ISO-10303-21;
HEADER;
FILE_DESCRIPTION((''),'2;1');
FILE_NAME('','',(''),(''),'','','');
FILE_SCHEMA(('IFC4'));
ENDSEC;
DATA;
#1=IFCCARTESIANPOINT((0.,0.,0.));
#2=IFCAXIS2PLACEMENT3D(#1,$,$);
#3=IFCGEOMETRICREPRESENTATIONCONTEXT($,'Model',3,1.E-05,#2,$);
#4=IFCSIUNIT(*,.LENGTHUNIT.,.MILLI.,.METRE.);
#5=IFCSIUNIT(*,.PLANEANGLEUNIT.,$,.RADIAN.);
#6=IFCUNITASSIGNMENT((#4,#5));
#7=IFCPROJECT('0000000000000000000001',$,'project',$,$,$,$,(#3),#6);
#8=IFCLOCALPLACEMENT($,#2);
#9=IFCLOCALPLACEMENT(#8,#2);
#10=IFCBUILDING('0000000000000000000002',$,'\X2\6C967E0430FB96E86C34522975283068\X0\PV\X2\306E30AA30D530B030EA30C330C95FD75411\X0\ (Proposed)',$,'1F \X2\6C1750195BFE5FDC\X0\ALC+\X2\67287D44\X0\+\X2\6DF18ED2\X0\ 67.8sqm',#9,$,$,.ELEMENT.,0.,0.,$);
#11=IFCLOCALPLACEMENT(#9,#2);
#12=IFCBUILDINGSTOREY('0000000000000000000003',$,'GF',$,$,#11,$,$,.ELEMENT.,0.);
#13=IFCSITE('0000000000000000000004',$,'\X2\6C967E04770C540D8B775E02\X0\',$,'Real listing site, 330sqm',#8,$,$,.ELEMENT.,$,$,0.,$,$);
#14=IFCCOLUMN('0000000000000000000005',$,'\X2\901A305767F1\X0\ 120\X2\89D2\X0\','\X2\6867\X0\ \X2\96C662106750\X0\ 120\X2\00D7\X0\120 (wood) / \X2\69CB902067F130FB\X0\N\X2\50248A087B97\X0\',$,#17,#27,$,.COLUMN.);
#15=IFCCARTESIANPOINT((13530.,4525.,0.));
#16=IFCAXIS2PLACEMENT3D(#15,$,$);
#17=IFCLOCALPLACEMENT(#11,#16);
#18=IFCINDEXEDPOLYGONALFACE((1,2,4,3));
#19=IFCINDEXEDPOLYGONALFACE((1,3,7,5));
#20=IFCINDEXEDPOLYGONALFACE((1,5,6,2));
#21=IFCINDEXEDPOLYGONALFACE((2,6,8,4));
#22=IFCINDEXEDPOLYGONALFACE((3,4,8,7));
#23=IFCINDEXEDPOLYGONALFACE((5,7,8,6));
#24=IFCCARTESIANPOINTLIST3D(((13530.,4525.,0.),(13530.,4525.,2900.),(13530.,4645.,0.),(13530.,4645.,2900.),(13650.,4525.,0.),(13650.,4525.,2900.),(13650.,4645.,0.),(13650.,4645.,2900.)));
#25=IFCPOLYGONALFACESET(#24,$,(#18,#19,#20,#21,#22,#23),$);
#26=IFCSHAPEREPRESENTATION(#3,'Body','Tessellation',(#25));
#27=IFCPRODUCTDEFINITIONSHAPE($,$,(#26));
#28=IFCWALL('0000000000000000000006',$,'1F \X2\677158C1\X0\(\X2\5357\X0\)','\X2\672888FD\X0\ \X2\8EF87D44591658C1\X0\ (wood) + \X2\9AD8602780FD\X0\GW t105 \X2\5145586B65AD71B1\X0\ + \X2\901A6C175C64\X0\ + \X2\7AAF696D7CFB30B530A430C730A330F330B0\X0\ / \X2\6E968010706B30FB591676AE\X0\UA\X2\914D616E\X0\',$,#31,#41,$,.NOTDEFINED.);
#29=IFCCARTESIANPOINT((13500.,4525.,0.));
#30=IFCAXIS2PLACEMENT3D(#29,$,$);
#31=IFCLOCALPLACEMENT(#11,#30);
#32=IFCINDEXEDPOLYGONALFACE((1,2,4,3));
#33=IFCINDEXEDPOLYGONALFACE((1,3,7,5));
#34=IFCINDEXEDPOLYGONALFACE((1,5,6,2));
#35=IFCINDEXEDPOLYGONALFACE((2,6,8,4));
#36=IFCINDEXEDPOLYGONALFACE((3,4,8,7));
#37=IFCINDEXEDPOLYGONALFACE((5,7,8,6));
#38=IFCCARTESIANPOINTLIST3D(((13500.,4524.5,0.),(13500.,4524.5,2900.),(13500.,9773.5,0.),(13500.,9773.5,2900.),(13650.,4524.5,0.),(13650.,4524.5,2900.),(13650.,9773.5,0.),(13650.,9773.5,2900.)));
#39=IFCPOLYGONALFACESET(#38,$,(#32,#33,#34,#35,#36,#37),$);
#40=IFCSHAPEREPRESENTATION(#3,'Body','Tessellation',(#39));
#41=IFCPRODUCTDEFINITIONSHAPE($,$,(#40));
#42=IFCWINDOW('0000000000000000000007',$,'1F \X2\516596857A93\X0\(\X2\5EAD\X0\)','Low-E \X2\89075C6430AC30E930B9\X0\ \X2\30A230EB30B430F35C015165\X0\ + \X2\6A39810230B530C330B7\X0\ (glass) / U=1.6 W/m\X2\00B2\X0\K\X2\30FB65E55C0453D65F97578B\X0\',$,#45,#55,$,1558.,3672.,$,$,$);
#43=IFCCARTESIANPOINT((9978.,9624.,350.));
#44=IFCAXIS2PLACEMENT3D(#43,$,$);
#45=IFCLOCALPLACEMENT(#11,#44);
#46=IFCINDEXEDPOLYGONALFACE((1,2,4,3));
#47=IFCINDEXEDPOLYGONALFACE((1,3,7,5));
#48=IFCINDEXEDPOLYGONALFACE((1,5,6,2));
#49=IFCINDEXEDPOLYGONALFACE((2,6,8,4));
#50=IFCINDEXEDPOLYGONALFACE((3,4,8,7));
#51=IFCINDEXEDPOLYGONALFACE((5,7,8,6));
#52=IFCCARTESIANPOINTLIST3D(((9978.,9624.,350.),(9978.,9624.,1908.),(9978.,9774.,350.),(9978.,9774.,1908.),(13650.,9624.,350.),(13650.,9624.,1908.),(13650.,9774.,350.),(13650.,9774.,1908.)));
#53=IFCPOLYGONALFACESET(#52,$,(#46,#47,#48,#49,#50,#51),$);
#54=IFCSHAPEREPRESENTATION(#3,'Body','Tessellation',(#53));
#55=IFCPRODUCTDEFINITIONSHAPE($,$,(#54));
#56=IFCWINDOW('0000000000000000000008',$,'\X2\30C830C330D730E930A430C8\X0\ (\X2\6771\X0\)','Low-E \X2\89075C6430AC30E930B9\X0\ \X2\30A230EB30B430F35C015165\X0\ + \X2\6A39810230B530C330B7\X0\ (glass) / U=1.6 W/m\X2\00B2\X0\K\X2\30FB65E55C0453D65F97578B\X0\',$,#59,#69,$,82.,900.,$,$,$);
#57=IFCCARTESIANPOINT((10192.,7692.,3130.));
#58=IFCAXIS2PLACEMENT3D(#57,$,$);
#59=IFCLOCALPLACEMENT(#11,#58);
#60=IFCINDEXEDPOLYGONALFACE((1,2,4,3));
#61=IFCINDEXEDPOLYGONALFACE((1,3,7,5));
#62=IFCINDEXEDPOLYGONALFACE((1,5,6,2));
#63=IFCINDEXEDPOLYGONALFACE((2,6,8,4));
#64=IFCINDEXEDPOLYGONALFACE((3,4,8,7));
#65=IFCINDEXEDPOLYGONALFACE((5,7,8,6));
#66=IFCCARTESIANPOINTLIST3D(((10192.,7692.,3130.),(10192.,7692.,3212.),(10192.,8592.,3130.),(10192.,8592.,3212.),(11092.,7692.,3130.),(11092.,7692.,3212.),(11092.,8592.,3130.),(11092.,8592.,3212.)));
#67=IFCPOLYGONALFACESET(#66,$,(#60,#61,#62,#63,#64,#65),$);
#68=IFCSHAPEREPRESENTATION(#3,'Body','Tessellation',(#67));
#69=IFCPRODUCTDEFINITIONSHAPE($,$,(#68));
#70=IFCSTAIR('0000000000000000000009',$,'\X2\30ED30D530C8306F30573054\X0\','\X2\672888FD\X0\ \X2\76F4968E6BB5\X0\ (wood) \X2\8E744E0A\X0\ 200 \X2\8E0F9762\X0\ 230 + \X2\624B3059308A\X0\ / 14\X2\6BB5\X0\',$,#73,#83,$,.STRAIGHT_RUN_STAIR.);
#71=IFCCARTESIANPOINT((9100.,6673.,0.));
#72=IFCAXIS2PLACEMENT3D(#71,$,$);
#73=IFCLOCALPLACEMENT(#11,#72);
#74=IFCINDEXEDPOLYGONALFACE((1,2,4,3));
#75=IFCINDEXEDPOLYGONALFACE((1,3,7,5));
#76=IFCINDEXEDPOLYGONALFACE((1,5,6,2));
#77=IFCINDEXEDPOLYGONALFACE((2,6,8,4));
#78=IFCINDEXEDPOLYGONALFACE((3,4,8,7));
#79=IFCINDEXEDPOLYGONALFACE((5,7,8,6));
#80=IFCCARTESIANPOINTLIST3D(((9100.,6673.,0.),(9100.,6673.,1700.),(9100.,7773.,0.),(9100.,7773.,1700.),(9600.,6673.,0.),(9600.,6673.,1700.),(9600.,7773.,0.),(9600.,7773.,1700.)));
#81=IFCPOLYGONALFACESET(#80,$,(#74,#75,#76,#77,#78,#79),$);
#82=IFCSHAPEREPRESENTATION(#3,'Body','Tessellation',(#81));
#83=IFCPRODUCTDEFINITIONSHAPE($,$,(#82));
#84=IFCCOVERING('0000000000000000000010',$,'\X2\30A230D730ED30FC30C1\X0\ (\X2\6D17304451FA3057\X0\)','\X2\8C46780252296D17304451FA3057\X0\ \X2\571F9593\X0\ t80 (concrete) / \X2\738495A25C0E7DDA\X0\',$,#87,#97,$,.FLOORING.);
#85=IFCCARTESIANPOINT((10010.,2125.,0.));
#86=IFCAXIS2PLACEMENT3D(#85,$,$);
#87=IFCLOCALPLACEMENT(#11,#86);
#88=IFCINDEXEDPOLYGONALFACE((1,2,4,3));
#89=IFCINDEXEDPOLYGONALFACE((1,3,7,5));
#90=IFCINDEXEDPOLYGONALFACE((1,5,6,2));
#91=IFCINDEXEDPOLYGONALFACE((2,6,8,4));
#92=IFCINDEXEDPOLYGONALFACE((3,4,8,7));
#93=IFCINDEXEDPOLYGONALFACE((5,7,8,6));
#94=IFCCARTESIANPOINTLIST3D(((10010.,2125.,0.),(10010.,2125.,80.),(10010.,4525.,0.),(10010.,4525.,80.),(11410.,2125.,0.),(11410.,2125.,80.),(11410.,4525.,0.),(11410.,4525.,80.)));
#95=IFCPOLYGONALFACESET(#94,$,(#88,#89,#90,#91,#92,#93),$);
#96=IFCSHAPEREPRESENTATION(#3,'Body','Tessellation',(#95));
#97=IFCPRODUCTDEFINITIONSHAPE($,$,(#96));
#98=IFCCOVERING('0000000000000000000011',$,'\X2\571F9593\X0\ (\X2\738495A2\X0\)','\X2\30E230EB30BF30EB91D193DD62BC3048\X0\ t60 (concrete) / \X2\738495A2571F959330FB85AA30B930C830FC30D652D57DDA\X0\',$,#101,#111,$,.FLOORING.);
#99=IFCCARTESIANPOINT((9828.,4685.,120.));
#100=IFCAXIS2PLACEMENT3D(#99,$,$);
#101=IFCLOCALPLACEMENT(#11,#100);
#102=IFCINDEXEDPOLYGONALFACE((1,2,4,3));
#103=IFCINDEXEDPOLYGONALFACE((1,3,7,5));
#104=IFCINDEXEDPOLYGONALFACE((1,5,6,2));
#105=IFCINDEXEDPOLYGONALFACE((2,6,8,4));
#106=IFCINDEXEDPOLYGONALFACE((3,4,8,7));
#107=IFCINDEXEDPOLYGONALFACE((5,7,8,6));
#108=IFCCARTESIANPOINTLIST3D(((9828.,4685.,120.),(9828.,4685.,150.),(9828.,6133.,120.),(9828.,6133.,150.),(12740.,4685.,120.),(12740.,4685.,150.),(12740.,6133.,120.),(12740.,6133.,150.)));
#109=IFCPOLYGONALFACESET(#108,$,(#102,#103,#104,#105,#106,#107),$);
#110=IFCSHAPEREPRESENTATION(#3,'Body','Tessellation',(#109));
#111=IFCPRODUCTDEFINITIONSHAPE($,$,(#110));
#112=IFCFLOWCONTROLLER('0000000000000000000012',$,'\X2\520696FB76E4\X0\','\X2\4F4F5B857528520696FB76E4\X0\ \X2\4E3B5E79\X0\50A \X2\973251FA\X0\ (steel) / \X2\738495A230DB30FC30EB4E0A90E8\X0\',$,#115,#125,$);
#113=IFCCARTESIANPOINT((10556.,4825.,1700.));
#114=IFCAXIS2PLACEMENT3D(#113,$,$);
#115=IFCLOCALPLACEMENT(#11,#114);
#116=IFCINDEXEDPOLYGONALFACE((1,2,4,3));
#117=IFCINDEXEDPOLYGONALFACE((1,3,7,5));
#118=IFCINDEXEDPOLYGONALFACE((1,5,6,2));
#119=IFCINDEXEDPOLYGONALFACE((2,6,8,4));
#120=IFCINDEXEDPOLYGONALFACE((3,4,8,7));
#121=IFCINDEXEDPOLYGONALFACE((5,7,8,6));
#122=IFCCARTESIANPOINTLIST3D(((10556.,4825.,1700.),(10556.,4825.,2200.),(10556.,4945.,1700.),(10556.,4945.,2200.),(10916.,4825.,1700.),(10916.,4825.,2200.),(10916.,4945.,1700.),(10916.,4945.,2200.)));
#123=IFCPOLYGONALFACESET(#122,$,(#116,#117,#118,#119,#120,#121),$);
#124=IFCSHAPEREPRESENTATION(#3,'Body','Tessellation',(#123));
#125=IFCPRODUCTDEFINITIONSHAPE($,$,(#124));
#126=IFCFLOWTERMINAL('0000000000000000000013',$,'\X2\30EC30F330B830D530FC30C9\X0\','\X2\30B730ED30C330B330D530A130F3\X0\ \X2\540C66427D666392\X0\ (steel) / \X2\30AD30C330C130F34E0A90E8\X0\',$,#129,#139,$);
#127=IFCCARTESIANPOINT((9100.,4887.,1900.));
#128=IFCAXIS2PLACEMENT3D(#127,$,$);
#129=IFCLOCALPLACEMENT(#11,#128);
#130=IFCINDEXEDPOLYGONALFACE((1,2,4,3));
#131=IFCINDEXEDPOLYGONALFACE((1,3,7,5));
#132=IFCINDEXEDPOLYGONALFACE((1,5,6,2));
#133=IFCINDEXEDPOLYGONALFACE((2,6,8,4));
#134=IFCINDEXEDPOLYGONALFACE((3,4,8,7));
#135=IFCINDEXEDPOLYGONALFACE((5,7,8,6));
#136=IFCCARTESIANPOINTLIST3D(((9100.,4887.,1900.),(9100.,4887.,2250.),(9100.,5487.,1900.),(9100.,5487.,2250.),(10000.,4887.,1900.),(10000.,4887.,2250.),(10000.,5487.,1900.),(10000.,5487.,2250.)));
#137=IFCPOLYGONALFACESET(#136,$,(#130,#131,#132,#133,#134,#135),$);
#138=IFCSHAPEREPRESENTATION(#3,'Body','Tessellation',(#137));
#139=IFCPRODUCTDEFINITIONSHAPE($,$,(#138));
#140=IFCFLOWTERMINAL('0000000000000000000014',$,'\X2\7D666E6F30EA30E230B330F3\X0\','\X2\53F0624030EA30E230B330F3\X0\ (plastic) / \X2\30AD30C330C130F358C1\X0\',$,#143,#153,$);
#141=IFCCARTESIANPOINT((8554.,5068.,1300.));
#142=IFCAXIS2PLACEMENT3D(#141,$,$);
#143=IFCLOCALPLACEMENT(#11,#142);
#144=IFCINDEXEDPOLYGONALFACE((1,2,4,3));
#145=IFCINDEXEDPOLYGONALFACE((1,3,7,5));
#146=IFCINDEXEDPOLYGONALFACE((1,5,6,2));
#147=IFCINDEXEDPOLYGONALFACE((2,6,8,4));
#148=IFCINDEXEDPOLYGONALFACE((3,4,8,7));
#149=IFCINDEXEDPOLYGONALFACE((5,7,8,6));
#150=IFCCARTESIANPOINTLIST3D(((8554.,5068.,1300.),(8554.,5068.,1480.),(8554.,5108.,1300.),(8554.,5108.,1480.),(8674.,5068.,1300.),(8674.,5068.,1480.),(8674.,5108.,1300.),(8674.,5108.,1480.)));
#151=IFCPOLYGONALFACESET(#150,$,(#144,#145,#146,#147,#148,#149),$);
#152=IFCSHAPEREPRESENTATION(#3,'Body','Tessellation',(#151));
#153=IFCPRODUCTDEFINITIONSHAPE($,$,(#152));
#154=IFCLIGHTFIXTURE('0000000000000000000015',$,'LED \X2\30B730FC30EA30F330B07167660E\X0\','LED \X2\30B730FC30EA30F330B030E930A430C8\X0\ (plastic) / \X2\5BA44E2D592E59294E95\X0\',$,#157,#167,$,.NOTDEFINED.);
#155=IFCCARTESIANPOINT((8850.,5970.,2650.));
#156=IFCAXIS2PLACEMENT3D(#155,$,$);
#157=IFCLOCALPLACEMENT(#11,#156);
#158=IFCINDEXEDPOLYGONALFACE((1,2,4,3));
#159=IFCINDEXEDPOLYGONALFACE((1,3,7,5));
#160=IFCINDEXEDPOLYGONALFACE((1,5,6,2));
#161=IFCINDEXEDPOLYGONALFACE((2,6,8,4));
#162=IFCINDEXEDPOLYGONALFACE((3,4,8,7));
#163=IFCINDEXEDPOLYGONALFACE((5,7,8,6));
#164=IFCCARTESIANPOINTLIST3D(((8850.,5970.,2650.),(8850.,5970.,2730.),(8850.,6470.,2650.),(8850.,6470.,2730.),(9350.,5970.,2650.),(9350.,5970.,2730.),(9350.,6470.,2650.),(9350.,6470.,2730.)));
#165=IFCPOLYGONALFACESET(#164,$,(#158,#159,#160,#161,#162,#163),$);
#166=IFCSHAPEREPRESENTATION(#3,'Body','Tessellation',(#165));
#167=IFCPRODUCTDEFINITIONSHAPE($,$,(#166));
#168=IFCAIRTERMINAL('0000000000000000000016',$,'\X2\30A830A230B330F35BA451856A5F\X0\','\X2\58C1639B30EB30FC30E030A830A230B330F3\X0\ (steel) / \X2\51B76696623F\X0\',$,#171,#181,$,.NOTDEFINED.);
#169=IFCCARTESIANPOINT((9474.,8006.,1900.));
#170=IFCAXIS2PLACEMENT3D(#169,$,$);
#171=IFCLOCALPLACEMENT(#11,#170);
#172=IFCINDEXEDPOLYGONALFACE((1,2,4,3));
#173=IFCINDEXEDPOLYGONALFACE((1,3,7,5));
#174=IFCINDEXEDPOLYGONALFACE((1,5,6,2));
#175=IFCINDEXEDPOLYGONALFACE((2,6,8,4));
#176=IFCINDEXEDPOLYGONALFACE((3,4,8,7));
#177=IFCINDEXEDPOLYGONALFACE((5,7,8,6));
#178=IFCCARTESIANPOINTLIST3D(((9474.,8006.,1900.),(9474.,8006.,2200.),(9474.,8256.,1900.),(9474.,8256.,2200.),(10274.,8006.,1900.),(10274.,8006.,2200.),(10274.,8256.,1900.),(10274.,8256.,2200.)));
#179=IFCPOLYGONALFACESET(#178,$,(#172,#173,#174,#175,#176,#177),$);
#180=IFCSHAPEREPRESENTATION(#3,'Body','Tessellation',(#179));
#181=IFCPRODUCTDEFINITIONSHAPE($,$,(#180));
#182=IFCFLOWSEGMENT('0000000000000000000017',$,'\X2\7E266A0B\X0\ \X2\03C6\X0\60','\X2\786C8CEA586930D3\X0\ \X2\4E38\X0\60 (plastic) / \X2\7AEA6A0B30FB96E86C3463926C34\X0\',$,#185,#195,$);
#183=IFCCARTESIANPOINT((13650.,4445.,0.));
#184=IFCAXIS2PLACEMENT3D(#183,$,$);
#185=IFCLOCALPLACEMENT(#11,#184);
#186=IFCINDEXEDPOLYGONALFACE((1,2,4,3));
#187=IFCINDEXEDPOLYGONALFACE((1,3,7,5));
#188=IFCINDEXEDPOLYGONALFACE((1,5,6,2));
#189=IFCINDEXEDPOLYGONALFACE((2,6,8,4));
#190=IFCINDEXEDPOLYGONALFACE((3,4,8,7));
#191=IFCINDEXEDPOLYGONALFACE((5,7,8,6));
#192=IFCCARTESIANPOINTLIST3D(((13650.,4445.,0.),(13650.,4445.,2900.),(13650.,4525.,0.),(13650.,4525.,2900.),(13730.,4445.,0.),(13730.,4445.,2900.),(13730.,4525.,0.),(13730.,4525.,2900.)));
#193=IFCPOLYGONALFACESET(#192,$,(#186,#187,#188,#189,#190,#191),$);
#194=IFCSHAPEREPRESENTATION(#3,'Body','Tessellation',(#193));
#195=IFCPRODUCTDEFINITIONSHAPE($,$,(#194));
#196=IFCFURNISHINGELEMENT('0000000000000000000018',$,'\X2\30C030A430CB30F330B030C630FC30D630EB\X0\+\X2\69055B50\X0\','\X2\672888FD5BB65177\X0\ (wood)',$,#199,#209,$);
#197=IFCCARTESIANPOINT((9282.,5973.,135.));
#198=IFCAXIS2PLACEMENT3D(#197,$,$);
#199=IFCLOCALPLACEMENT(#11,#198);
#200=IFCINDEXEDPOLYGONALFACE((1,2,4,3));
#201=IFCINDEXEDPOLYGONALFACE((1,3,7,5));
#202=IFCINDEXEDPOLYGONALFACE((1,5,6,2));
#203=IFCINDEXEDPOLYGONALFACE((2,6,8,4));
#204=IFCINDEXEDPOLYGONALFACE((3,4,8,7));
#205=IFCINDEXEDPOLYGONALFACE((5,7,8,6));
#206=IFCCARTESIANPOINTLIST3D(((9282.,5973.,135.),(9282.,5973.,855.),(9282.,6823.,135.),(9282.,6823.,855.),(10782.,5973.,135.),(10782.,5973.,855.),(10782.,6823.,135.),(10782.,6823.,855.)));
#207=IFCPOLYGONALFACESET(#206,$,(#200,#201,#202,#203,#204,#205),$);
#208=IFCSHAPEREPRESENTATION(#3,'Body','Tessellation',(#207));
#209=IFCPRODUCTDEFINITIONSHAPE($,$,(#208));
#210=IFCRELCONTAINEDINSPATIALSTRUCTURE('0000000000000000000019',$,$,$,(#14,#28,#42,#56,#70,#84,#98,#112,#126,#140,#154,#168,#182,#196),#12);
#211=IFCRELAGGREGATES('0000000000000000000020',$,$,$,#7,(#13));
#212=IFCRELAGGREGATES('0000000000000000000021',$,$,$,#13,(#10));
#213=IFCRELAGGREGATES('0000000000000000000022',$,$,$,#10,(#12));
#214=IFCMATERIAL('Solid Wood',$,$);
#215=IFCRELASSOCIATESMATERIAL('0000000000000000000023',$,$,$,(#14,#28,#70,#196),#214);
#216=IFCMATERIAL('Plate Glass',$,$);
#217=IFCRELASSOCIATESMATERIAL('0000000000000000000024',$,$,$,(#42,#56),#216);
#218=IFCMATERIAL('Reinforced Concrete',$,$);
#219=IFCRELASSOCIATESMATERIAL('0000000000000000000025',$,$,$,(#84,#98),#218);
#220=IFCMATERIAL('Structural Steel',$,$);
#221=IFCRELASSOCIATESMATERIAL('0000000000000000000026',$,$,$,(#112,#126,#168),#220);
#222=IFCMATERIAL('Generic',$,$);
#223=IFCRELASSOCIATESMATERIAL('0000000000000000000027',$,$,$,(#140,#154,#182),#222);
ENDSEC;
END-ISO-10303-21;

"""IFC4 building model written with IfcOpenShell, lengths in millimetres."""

from ifc_helpers import new_model, si_unit, frame, frame_2d, origin, place, context, project, spatial, rectangle, extrude, material, element, fill, save


model = new_model("IFC4")

# Units and contexts
model_context = context("Model", 3, precision=1e-05, world=origin())
ifc_project = project(units=[si_unit("LENGTHUNIT", "METRE", prefix="MILLI"), si_unit("PLANEANGLEUNIT", "RADIAN")], contexts=[model_context])

# Site, building, storey
site_placement = place(None, origin())
site = spatial("IfcSite", under=ifc_project, at=site_placement, Name="沖縄県名護市", ObjectType="Real listing site, 330sqm", CompositionType="ELEMENT", RefElevation=0.0)
building_placement = place(site_placement, origin())
building = spatial("IfcBuilding", under=site, at=building_placement, Name="沖縄・雨水利用とPVのオフグリッド志向 (Proposed)", ObjectType="1F 気候対応ALC+木組+深軒 67.8sqm", CompositionType="ELEMENT", ElevationOfRefHeight=0.0, ElevationOfTerrain=0.0)
storey_placement = place(building_placement, origin())
storey = spatial("IfcBuildingStorey", under=building, at=storey_placement, Name="GF", CompositionType="ELEMENT", Elevation=0.0)

# Column
ifc_material_1 = material(Name="Solid Wood")
column_1_placement = place(storey_placement, frame((13530.0, 4525.0, 0.0)))
element("IfcColumn", 1, at=column_1_placement, inside=storey, material=ifc_material_1, Name="通し柱 120角", Description="桧 集成材 120×120 (wood) / 構造柱・N値計算", PredefinedType="COLUMN", context=model_context, shape_type="SweptSolid", body=[
    extrude(rectangle(XDim=120.0, YDim=120.0, at=frame_2d((60.0, 60.0))), frame((13530.0, 4525.0, 0.0)), (0.0, 0.0, 1.0), 2900.0),
])

# Wall, opening, window
wall_1_placement = place(storey_placement, frame((13500.0, 4525.0, 0.0)))
wall_1 = element("IfcWall", 2, at=wall_1_placement, inside=storey, material=ifc_material_1, Name="1F 東壁(南)", Description="木製 軸組外壁 (wood) + 高性能GW t105 充填断熱 + 通気層 + 窯業系サイディング / 準耐火・外皮UA配慮", PredefinedType="NOTDEFINED", context=model_context, shape_type="SweptSolid", body=[
    extrude(rectangle(XDim=150.0, YDim=5249.0, at=frame_2d((75.0, 2624.0))), frame((13500.0, 4525.0, 0.0)), (0.0, 0.0, 1.0), 2900.0),
])
opening_placement = place(storey_placement, frame((9978.0, 9624.0, 350.0)))
opening = element("IfcOpeningElement", 3, at=opening_placement, cuts=wall_1, PredefinedType="NOTDEFINED", context=model_context, shape_type="SweptSolid", body=[
    extrude(rectangle(XDim=3672.0, YDim=150.0, at=frame_2d((1836.0, 75.0))), frame((9978.0, 9624.0, 350.0)), (0.0, 0.0, 1.0), 1558.0),
])
ifc_material_2 = material(Name="Plate Glass")
window_1_placement = place(storey_placement, frame((9978.0, 9624.0, 350.0)))
window_1 = element("IfcWindow", 4, at=window_1_placement, inside=storey, material=ifc_material_2, Name="1F 入隅窓(庭)", Description="Low-E 複層ガラス アルゴン封入 + 樹脂サッシ (glass) / U=1.6 W/m²K・日射取得型", OverallHeight=1558.0, OverallWidth=3672.0, context=model_context, shape_type="SweptSolid", body=[
    extrude(rectangle(XDim=3672.0, YDim=150.0, at=frame_2d((1836.0, 75.0))), frame((9978.0, 9624.0, 350.0)), (0.0, 0.0, 1.0), 1558.0),
])
fill(opening, window_1)

# Window
window_2_placement = place(storey_placement, frame((10192.0, 7692.0, 3130.0)))
element("IfcWindow", 5, at=window_2_placement, inside=storey, material=ifc_material_2, Name="トップライト (東)", Description="Low-E 複層ガラス アルゴン封入 + 樹脂サッシ (glass) / U=1.6 W/m²K・日射取得型", OverallHeight=82.0, OverallWidth=900.0, context=model_context, shape_type="SweptSolid", body=[
    extrude(rectangle(XDim=900.0, YDim=900.0, at=frame_2d((450.0, 450.0))), frame((10192.0, 7692.0, 3130.0)), (0.0, 0.0, 1.0), 82.0),
])

# Stair
stair_placement = place(storey_placement, frame((9100.0, 6673.0, 0.0)))
element("IfcStair", 6, at=stair_placement, inside=storey, material=ifc_material_1, Name="ロフトはしご", Description="木製 直階段 (wood) 蹴上 200 踏面 230 + 手すり / 14段", PredefinedType="STRAIGHT_RUN_STAIR", context=model_context, shape_type="SweptSolid", body=[
    extrude(rectangle(XDim=500.0, YDim=1100.0, at=frame_2d((250.0, 550.0))), frame((9100.0, 6673.0, 0.0)), (0.0, 0.0, 1.0), 1700.0),
])

# Coverings
ifc_material_3 = material(Name="Reinforced Concrete")
covering_1_placement = place(storey_placement, frame((10010.0, 2125.0, 0.0)))
element("IfcCovering", 7, at=covering_1_placement, inside=storey, material=ifc_material_3, Name="アプローチ (洗い出し)", Description="豆砂利洗い出し 土間 t80 (concrete) / 玄関導線", PredefinedType="FLOORING", context=model_context, shape_type="SweptSolid", body=[
    extrude(rectangle(XDim=1400.0, YDim=2400.0, at=frame_2d((700.0, 1200.0))), frame((10010.0, 2125.0, 0.0)), (0.0, 0.0, 1.0), 80.0),
])
covering_2_placement = place(storey_placement, frame((9828.0, 4685.0, 120.0)))
element("IfcCovering", 8, at=covering_2_placement, inside=storey, material=ifc_material_3, Name="土間 (玄関)", Description="モルタル金鏝押え t60 (concrete) / 玄関土間・薪ストーブ動線", PredefinedType="FLOORING", context=model_context, shape_type="SweptSolid", body=[
    extrude(rectangle(XDim=2912.0, YDim=1448.0, at=frame_2d((1456.0, 724.0))), frame((9828.0, 4685.0, 120.0)), (0.0, 0.0, 1.0), 30.0),
])

# Flow controller
ifc_material_4 = material(Name="Structural Steel")
flow_controller_placement = place(storey_placement, frame((10556.0, 4825.0, 1700.0)))
element("IfcFlowController", 9, at=flow_controller_placement, inside=storey, material=ifc_material_4, Name="分電盤", Description="住宅用分電盤 主幹50A 露出 (steel) / 玄関ホール上部", context=model_context, shape_type="SweptSolid", body=[
    extrude(rectangle(XDim=360.0, YDim=120.0, at=frame_2d((180.0, 60.0))), frame((10556.0, 4825.0, 1700.0)), (0.0, 0.0, 1.0), 500.0),
])

# Flow terminals
flow_terminal_1_placement = place(storey_placement, frame((9100.0, 4887.0, 1900.0)))
element("IfcFlowTerminal", 10, at=flow_terminal_1_placement, inside=storey, material=ifc_material_4, Name="レンジフード", Description="シロッコファン 同時給排 (steel) / キッチン上部", context=model_context, shape_type="SweptSolid", body=[
    extrude(rectangle(XDim=900.0, YDim=600.0, at=frame_2d((450.0, 300.0))), frame((9100.0, 4887.0, 1900.0)), (0.0, 0.0, 1.0), 350.0),
])
ifc_material_5 = material(Name="Generic")
flow_terminal_2_placement = place(storey_placement, frame((8554.0, 5068.0, 1300.0)))
element("IfcFlowTerminal", 11, at=flow_terminal_2_placement, inside=storey, material=ifc_material_5, Name="給湯リモコン", Description="台所リモコン (plastic) / キッチン壁", context=model_context, shape_type="SweptSolid", body=[
    extrude(rectangle(XDim=120.0, YDim=40.0, at=frame_2d((60.0, 20.0))), frame((8554.0, 5068.0, 1300.0)), (0.0, 0.0, 1.0), 180.0),
])

# Light fixture
light_fixture_placement = place(storey_placement, frame((8850.0, 5970.0, 2650.0)))
element("IfcLightFixture", 12, at=light_fixture_placement, inside=storey, material=ifc_material_5, Name="LED シーリング照明", Description="LED シーリングライト (plastic) / 室中央天井", PredefinedType="NOTDEFINED", context=model_context, shape_type="SweptSolid", body=[
    extrude(rectangle(XDim=500.0, YDim=500.0, at=frame_2d((250.0, 250.0))), frame((8850.0, 5970.0, 2650.0)), (0.0, 0.0, 1.0), 80.0),
])

# Air terminal
air_terminal_placement = place(storey_placement, frame((9474.0, 8006.0, 1900.0)))
element("IfcAirTerminal", 13, at=air_terminal_placement, inside=storey, material=ifc_material_4, Name="エアコン室内機", Description="壁掛ルームエアコン (steel) / 冷暖房", PredefinedType="NOTDEFINED", context=model_context, shape_type="SweptSolid", body=[
    extrude(rectangle(XDim=800.0, YDim=250.0, at=frame_2d((400.0, 125.0))), frame((9474.0, 8006.0, 1900.0)), (0.0, 0.0, 1.0), 300.0),
])

# Flow segment
flow_segment_placement = place(storey_placement, frame((13650.0, 4445.0, 0.0)))
element("IfcFlowSegment", 14, at=flow_segment_placement, inside=storey, material=ifc_material_5, Name="縦樋 φ60", Description="硬質塩ビ 丸60 (plastic) / 竪樋・雨水排水", context=model_context, shape_type="SweptSolid", body=[
    extrude(rectangle(XDim=80.0, YDim=80.0, at=frame_2d((40.0, 40.0))), frame((13650.0, 4445.0, 0.0)), (0.0, 0.0, 1.0), 2900.0),
])

# Furnishing element
furnishing_1_placement = place(storey_placement, frame((9282.0, 5973.0, 135.0)))
element("IfcFurnishingElement", 15, at=furnishing_1_placement, inside=storey, material=ifc_material_1, Name="ダイニングテーブル+椅子", Description="木製家具 (wood)", context=model_context, shape_type="SweptSolid", body=[
    extrude(rectangle(XDim=1500.0, YDim=850.0, at=frame_2d((750.0, 425.0))), frame((9282.0, 5973.0, 135.0)), (0.0, 0.0, 1.0), 720.0),
])

save(model, "model.ifc")
